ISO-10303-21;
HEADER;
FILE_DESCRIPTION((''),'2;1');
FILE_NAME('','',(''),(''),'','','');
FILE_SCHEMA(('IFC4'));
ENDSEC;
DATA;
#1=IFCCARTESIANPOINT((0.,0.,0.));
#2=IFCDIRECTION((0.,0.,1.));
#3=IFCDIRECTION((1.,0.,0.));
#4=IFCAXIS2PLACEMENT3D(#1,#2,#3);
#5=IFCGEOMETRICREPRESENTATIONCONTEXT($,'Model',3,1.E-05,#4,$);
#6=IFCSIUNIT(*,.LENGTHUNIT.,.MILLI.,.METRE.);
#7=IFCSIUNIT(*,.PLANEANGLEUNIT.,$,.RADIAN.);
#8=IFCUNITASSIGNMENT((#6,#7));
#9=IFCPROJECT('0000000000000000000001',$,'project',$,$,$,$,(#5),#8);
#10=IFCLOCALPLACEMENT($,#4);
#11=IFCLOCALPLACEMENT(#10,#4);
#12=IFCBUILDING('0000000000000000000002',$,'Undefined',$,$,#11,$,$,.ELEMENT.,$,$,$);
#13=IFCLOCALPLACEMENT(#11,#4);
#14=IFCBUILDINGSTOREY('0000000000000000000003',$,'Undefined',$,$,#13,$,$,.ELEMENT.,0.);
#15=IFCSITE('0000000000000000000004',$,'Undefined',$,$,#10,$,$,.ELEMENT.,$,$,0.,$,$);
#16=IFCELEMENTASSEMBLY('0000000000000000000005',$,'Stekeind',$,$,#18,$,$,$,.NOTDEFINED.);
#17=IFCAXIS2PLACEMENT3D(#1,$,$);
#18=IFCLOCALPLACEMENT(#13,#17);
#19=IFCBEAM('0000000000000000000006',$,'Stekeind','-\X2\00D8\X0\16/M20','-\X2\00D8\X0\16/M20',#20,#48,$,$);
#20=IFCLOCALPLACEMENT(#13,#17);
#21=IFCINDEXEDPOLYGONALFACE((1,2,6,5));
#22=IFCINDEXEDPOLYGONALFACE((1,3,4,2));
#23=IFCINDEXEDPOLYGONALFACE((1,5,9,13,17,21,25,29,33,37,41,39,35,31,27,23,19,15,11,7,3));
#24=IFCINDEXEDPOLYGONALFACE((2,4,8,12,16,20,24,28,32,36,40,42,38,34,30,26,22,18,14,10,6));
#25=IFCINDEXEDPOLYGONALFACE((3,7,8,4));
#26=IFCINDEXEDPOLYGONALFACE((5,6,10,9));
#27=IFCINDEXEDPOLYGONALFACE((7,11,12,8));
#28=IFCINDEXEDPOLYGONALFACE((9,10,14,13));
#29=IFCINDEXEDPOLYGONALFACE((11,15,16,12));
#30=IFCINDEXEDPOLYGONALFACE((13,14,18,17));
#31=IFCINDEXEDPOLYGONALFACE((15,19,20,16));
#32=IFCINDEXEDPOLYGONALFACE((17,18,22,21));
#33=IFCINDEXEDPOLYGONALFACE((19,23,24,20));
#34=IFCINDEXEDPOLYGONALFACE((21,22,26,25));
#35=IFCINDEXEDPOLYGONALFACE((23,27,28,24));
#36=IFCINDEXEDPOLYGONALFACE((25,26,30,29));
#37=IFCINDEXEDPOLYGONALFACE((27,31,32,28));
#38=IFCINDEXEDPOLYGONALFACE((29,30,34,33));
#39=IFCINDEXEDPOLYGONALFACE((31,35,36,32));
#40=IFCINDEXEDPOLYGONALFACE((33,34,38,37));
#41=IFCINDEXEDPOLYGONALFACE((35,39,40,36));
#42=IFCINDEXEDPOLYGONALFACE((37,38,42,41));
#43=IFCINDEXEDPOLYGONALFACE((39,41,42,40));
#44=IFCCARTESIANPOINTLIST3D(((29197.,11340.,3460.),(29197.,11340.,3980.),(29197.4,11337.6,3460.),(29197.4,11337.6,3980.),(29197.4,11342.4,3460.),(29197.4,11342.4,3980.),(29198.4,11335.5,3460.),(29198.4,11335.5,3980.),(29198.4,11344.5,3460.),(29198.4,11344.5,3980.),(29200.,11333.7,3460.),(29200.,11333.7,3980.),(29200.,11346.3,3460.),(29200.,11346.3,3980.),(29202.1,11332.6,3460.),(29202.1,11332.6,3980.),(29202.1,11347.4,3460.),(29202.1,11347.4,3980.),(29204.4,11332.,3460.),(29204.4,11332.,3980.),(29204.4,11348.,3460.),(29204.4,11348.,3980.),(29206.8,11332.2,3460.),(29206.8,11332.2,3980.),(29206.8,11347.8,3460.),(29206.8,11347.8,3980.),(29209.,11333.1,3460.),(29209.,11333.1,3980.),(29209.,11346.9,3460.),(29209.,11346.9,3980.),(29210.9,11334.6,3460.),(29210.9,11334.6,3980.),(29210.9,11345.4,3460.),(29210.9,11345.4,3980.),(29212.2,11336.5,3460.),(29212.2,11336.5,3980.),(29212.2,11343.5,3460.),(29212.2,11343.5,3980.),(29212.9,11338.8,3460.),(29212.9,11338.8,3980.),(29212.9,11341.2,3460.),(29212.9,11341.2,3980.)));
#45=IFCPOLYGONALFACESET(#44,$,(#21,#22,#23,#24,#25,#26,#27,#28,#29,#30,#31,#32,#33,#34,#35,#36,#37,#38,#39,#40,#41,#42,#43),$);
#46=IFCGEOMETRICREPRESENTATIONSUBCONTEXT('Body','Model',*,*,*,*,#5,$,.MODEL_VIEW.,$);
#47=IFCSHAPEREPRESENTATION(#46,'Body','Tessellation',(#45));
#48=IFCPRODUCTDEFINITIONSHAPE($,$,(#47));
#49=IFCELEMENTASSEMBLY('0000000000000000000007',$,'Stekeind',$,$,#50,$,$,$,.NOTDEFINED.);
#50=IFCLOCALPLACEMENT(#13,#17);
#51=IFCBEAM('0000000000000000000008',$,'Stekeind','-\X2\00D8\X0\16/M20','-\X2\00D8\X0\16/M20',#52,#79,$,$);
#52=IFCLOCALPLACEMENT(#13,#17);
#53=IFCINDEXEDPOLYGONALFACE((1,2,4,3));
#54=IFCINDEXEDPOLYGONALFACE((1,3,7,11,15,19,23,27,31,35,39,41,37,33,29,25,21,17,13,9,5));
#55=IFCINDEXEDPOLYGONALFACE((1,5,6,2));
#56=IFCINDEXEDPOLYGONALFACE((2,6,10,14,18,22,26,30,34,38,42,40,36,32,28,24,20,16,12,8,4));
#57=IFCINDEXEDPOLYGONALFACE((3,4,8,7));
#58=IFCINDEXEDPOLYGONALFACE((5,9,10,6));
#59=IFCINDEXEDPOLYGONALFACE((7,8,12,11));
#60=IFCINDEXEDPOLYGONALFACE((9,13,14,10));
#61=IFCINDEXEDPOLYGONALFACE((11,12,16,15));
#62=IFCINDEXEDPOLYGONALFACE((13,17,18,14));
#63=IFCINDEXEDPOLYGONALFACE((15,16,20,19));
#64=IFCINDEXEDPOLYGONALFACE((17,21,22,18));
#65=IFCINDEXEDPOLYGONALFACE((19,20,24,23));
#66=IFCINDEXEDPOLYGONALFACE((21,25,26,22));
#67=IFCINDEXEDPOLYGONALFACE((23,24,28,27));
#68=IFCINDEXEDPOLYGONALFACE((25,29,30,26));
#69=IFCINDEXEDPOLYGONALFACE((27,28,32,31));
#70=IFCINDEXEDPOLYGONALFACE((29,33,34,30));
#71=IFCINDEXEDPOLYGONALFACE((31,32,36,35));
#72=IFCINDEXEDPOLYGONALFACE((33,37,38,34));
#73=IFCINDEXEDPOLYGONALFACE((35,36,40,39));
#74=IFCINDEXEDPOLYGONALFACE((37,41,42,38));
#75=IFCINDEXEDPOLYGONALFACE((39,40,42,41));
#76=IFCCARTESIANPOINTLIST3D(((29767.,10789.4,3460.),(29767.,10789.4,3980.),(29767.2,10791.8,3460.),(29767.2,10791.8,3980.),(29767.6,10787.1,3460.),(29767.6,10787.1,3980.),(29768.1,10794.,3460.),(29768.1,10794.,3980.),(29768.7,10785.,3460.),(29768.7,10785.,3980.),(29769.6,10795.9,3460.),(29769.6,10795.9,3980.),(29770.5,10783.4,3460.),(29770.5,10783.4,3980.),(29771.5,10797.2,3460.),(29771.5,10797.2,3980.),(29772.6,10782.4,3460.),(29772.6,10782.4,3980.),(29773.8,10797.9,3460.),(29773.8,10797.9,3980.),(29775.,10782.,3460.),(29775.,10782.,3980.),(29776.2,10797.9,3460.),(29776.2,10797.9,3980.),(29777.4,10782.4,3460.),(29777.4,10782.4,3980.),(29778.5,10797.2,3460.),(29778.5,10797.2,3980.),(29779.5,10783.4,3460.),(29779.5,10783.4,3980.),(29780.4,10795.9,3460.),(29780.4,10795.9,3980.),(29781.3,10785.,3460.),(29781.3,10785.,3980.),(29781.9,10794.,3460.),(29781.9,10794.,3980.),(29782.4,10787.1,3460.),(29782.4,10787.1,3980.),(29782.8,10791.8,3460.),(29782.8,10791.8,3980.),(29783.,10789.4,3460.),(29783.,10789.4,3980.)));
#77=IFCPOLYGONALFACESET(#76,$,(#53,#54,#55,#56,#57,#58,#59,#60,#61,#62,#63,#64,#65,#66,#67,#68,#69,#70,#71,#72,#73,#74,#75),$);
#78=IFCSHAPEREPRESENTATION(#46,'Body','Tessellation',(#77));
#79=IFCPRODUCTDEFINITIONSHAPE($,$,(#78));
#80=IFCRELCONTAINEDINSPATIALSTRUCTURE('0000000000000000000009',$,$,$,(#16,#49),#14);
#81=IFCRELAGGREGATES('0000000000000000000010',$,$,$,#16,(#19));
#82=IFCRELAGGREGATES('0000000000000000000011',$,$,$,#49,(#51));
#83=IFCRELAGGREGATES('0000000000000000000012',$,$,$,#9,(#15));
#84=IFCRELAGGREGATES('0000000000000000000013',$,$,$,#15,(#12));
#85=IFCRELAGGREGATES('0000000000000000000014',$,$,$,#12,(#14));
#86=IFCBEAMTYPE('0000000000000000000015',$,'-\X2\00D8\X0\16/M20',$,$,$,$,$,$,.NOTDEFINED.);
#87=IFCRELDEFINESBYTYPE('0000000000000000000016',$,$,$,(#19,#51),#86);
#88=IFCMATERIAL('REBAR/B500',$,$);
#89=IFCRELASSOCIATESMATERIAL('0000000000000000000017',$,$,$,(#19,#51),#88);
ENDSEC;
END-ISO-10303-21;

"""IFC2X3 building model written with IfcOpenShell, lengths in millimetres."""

from ifc_helpers import new_model, si_unit, frame, origin_with_axes, origin_2d_with_axis, place, context, subcontext, project, spatial, circle, extrude, material, type_object, element, aggregate, save


model = new_model("IFC2X3")

# Units and contexts
model_context = context("Model", 3, precision=1e-05, world=origin_with_axes())
body_context = subcontext(model_context, "Body", "Model", "MODEL_VIEW")
ifc_project = project(units=[si_unit("LENGTHUNIT", "METRE", prefix="MILLI"), si_unit("PLANEANGLEUNIT", "RADIAN")], contexts=[model_context])

# Site, building, storey
site_placement = place(None, origin_with_axes())
site = spatial("IfcSite", under=ifc_project, at=site_placement, Name="Undefined", CompositionType="ELEMENT", RefElevation=0.0)
building_placement = place(site_placement, origin_with_axes())
building = spatial("IfcBuilding", under=site, at=building_placement, Name="Undefined", CompositionType="ELEMENT")
storey_placement = place(building_placement, origin_with_axes())
storey = spatial("IfcBuildingStorey", under=building, at=storey_placement, Name="Undefined", CompositionType="ELEMENT", Elevation=0.0)

# Element assemblies, beams
ifc_material_1 = material(Name="REBAR/B500")
beam_type_1 = type_object("IfcBeamType", Name="-Ø16/M20", PredefinedType="NOTDEFINED")
assembly_1_placement = place(storey_placement, origin_with_axes())
assembly_1 = element("IfcElementAssembly", 1, at=assembly_1_placement, inside=storey, Name="Stekeind", PredefinedType="NOTDEFINED")
beam_1_placement = place(assembly_1_placement, frame((29205.0, 11340.0, 3980.0), z_axis=(0.0, -1.0, 0.0), x_axis=(0.0, 0.0, -1.0)))
beam_1 = element("IfcBeam", 2, at=beam_1_placement, type_object=beam_type_1, material=ifc_material_1, Name="Stekeind", Description="-Ø16/M20", ObjectType="-Ø16/M20", context=body_context, shape_type="SweptSolid", body=[
    extrude(circle(Radius=8.0, at=origin_2d_with_axis()), frame((520.0, 0.0, 0.0), z_axis=(-1.0, 0.0, 0.0), x_axis=(0.0, -1.0, 0.0)), (0.0, 0.0, 1.0), 520.0),
])
aggregate(assembly_1, [beam_1])
assembly_2_placement = place(storey_placement, origin_with_axes())
assembly_2 = element("IfcElementAssembly", 3, at=assembly_2_placement, inside=storey, Name="Stekeind", PredefinedType="NOTDEFINED")
beam_2_placement = place(assembly_2_placement, frame((29775.0, 10790.0, 3980.0), z_axis=(1.0, 0.0, 0.0), x_axis=(0.0, 0.0, -1.0)))
beam_2 = element("IfcBeam", 4, at=beam_2_placement, type_object=beam_type_1, material=ifc_material_1, Name="Stekeind", Description="-Ø16/M20", ObjectType="-Ø16/M20", context=body_context, shape_type="SweptSolid", body=[
    extrude(circle(Radius=8.0, at=origin_2d_with_axis()), frame((520.0, 0.0, 0.0), z_axis=(-1.0, 0.0, 0.0), x_axis=(0.0, -1.0, 0.0)), (0.0, 0.0, 1.0), 520.0),
])
aggregate(assembly_2, [beam_2])

save(model, "model.ifc")
